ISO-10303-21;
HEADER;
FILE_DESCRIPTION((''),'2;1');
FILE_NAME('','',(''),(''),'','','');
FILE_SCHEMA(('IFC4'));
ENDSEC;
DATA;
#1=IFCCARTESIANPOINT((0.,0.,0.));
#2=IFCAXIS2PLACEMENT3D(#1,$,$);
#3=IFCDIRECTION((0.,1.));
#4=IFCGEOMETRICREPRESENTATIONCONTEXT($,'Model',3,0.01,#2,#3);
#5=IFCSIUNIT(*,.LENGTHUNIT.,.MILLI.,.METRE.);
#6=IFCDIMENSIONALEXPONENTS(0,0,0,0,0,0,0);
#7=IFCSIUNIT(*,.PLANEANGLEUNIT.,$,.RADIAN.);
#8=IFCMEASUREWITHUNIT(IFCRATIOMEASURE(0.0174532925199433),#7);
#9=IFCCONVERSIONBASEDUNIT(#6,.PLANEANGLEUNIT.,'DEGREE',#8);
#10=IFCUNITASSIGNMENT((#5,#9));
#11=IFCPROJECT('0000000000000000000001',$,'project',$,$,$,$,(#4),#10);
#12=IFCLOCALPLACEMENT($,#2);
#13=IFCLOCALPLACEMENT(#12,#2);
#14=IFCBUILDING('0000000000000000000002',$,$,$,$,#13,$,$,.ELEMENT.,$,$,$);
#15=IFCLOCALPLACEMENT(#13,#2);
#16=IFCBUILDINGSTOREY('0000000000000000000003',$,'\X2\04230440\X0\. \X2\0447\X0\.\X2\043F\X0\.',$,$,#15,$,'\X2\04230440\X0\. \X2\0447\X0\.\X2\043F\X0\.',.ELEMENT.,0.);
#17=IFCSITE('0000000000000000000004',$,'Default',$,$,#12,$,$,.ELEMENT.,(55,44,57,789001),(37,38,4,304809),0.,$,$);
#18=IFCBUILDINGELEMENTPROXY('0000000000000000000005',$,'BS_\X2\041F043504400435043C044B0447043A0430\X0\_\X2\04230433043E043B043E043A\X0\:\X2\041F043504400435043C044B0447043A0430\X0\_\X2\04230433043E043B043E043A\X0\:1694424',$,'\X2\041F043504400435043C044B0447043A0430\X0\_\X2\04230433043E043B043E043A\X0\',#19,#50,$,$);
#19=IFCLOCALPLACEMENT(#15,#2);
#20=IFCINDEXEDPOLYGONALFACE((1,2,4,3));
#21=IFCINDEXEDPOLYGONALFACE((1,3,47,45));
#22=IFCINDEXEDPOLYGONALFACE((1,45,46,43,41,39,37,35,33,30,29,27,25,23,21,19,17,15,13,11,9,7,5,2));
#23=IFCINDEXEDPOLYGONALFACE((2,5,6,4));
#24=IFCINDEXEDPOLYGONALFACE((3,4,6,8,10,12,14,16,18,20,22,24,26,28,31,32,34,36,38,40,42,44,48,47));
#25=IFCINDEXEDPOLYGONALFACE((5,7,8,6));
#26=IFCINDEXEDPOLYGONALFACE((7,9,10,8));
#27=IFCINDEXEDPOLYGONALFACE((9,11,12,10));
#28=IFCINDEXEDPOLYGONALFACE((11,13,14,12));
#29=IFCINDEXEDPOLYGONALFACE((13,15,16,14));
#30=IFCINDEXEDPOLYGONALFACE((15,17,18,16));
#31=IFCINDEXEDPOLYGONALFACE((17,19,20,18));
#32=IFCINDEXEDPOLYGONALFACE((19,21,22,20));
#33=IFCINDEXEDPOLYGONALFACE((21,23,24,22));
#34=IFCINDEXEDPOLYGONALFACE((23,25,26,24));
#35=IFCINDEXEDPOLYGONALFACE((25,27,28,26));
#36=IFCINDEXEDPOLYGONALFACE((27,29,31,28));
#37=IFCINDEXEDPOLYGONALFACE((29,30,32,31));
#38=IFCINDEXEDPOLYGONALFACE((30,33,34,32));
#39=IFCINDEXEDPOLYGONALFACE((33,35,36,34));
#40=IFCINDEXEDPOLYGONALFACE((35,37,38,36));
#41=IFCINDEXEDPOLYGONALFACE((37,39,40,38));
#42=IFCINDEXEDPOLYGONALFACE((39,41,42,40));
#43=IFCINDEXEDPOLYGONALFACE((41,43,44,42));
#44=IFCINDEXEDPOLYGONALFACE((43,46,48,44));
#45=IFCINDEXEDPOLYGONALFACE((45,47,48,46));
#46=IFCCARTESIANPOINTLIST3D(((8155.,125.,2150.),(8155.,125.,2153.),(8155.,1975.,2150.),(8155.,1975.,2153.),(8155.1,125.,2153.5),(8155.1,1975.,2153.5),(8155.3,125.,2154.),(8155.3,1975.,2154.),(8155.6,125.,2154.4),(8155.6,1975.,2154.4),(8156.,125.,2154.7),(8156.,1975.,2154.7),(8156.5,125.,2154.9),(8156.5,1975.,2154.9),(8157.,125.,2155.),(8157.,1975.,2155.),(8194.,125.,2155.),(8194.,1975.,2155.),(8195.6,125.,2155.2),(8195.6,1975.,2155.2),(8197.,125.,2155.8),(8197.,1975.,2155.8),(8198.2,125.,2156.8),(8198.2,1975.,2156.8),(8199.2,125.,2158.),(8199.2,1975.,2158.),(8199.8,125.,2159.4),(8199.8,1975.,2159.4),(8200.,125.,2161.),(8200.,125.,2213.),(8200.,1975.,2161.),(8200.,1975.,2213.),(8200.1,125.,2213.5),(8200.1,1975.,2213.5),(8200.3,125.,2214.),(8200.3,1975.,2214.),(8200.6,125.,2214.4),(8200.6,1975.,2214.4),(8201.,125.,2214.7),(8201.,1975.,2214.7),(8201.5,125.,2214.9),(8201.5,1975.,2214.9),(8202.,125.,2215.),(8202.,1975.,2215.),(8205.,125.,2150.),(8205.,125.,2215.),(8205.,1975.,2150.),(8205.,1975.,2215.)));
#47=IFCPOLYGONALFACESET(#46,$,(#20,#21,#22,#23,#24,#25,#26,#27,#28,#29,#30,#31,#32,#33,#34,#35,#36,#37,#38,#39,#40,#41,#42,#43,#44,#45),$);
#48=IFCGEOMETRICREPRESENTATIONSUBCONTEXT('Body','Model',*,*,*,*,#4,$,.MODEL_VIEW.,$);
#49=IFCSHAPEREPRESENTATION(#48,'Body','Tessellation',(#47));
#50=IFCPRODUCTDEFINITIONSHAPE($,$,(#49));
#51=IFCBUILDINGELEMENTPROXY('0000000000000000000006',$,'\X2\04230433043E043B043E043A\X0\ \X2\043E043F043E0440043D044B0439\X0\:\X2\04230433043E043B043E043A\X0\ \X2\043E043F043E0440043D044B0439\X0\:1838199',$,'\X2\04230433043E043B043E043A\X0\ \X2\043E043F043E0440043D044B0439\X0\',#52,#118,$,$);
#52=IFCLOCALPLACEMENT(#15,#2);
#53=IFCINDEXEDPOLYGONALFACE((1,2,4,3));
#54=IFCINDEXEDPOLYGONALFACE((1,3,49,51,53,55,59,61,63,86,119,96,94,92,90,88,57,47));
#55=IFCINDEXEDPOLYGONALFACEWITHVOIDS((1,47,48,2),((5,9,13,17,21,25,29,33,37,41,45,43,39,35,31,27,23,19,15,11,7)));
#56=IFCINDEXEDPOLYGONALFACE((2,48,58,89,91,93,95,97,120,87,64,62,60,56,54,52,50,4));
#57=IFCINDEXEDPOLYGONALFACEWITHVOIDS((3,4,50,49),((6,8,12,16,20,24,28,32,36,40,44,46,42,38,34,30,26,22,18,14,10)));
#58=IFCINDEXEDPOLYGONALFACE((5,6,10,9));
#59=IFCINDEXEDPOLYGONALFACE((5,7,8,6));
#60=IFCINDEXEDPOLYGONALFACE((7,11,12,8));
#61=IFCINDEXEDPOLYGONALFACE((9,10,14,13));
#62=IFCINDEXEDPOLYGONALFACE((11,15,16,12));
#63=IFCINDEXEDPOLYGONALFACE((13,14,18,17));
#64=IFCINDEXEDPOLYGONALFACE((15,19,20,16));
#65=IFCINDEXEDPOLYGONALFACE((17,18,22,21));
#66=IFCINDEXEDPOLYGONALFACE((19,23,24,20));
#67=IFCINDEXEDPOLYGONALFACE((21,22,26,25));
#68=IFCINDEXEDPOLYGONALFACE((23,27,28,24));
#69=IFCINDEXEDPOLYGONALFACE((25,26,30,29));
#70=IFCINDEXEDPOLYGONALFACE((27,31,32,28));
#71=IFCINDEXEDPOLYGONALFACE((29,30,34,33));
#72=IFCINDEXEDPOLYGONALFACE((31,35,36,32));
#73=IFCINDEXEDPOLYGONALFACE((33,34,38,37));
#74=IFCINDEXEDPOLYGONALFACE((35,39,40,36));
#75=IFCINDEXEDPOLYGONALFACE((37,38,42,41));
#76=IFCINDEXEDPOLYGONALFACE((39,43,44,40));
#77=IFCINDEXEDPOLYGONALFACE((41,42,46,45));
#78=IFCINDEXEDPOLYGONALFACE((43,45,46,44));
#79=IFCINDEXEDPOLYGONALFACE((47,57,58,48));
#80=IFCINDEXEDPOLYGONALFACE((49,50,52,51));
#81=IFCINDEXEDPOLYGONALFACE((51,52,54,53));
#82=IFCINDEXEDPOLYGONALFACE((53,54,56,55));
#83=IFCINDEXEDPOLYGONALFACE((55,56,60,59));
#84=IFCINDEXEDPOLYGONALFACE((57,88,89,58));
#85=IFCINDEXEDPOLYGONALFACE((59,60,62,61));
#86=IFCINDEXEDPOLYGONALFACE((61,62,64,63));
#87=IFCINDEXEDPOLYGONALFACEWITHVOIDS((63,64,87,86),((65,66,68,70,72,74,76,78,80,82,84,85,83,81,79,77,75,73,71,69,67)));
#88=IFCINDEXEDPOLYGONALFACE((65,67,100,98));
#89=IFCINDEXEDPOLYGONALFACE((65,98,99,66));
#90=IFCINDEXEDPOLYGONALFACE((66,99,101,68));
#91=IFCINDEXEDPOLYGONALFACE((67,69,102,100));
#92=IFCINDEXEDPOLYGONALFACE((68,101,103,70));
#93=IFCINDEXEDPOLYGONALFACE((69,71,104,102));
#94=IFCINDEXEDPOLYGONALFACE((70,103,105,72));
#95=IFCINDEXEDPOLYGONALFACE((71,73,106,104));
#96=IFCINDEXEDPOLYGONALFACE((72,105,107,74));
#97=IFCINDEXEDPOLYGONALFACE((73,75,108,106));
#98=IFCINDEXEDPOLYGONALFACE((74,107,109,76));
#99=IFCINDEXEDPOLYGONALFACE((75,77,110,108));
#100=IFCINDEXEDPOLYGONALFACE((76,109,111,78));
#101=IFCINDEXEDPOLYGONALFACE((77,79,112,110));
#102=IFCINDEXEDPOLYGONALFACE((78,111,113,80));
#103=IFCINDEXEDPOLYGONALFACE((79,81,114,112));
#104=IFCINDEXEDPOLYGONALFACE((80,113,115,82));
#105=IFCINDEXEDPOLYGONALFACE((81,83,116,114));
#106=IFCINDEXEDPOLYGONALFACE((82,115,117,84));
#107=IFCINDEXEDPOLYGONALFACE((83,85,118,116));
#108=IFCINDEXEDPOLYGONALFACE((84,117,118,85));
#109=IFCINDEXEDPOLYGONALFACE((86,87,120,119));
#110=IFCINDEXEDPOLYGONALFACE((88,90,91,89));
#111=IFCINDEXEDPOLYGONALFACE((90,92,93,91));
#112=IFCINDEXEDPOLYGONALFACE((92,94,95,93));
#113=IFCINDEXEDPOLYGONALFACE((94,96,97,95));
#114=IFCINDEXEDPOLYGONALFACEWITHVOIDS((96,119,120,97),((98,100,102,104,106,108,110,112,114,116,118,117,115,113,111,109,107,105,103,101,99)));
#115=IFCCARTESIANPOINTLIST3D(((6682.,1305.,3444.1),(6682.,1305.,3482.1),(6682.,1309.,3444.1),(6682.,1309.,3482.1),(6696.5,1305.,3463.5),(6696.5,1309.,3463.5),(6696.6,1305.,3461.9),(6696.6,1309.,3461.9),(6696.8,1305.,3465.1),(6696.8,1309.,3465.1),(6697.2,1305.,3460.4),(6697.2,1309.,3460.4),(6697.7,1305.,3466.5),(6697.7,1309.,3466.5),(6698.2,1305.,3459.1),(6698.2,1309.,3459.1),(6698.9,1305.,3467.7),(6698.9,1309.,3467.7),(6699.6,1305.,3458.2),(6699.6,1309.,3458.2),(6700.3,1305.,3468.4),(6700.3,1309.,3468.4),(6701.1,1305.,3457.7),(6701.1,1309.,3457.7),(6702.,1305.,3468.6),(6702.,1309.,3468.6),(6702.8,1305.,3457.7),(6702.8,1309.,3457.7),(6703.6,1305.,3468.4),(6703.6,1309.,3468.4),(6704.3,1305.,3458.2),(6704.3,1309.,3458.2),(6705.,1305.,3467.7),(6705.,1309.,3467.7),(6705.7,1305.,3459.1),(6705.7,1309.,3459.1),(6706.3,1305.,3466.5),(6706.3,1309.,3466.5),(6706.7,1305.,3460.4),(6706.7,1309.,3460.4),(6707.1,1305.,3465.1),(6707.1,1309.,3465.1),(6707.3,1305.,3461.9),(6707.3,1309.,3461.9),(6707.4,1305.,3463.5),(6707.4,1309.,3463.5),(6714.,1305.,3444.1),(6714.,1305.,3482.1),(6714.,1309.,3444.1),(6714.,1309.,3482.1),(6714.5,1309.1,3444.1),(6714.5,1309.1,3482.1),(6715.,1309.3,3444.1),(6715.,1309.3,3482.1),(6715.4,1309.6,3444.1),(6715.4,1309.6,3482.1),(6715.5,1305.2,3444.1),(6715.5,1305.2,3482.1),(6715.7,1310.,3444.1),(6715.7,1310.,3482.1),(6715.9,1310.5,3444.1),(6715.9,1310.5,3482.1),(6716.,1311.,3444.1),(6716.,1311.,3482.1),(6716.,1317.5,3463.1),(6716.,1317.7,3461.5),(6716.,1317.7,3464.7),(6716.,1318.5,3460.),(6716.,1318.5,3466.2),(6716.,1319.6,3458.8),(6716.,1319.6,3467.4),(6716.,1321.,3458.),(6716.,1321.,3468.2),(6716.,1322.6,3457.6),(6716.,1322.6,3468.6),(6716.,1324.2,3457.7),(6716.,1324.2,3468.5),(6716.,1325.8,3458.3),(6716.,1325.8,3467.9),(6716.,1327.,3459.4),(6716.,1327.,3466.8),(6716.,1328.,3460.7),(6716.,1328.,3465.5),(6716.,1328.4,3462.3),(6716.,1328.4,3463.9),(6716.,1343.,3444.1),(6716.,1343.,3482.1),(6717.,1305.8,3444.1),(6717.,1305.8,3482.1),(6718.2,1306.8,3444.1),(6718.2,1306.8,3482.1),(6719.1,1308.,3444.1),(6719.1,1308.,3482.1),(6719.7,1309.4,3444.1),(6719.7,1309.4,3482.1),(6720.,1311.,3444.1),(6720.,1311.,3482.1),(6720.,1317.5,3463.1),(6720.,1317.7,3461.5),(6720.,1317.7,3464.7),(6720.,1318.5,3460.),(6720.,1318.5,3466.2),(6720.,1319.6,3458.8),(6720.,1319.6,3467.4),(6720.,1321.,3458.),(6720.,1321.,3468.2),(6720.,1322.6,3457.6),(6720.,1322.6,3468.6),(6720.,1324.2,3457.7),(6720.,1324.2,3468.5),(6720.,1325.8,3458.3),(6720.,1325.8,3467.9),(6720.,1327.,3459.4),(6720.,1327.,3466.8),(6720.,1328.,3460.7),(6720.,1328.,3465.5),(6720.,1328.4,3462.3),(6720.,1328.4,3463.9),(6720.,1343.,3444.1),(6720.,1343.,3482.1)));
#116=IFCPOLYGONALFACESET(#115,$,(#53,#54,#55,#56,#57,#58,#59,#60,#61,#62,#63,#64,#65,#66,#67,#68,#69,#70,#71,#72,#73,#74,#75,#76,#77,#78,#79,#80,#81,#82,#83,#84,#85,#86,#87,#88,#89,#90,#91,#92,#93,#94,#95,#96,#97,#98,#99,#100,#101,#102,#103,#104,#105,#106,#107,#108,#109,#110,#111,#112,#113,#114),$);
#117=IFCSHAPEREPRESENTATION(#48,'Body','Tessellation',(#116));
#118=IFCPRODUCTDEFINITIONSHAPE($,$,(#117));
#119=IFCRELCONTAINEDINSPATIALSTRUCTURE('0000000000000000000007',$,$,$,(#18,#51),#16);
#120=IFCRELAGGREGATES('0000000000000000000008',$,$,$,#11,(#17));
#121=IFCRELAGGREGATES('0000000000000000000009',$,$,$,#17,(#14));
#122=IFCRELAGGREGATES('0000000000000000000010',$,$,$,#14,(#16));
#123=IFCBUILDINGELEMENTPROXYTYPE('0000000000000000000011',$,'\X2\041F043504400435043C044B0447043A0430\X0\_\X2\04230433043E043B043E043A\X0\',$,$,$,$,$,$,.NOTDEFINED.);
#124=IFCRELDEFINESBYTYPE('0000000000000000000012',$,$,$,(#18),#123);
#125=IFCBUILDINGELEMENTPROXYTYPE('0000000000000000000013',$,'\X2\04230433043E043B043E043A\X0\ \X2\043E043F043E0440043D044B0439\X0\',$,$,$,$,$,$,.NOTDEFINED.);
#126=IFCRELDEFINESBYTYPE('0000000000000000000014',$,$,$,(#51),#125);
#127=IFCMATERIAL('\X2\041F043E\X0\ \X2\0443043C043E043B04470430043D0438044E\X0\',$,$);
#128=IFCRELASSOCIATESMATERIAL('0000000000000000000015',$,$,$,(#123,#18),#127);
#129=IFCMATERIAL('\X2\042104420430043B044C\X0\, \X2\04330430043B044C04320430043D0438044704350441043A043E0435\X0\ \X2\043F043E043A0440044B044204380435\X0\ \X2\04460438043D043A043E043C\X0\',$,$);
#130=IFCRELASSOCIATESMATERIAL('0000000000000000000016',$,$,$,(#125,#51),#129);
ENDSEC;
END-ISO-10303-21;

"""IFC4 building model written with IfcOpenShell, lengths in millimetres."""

from ifc_helpers import new_model, entity, si_unit, converted_unit, direction, frame, frame_2d, origin, place, context, subcontext, project, spatial, polyline, circle_curve, parameter, trimmed, segment, composite_curve, circle, outline, extrude, source, transform, mapped, material, type_object, type_shapes, element, save


model = new_model("IFC4")

# Units and contexts
model_context = context("Model", 3, precision=0.01, world=origin(), true_north=direction((0.0, 1.0)))
body_context = subcontext(model_context, "Body", "Model", "MODEL_VIEW")
ifc_project = project(units=[si_unit("LENGTHUNIT", "METRE", prefix="MILLI"), converted_unit("PLANEANGLEUNIT", "DEGREE", entity("IfcRatioMeasure", 0.0174532925199433), si_unit("PLANEANGLEUNIT", "RADIAN"), dimensions=[0, 0, 0, 0, 0, 0, 0])], contexts=[model_context])

# Site, building, storey
site_placement = place(None, origin())
site = spatial("IfcSite", under=ifc_project, at=site_placement, Name="Default", CompositionType="ELEMENT", RefLatitude=(55, 44, 57, 789001), RefLongitude=(37, 38, 4, 304809), RefElevation=0.0)
building_placement = place(site_placement, origin())
building = spatial("IfcBuilding", under=site, at=building_placement, CompositionType="ELEMENT")
storey_placement = place(building_placement, origin())
storey = spatial("IfcBuildingStorey", under=building, at=storey_placement, Name="Ур. ч.п.", LongName="Ур. ч.п.", CompositionType="ELEMENT", Elevation=0.0)

# Building element proxy
ifc_material_1 = material(Name="По умолчанию")
building_element_proxy_type_1 = type_object("IfcBuildingElementProxyType", Name="Перемычка_Уголок", material=ifc_material_1)
shared_shape_1 = source(origin(), body_context, "Body", "SweptSolid", [
    extrude(outline(composite_curve([segment(polyline([(-24.1, -19.1), (40.9, -19.1)]), True, "CONTINUOUS"), segment(polyline([(40.9, -19.1), (40.9, -16.1)]), True, "CONTINUOUS"), segment(trimmed(circle_curve(frame_2d((38.9, -16.1), x_axis=(0.0, 1.0)), 2.0), [parameter(270.0)], [parameter(0.0)], True, "PARAMETER"), True, "CONTINUOUS"), segment(polyline([(38.9, -14.1), (-13.1, -14.1)]), True, "CONTINUOUS"), segment(trimmed(circle_curve(frame_2d((-13.1, -8.1), x_axis=(0.0, 1.0)), 6.0), [parameter(90.0)], [parameter(180.0)], True, "PARAMETER"), False, "CONTINUOUS"), segment(polyline([(-19.1, -8.1), (-19.1, 28.9)]), True, "CONTINUOUS"), segment(trimmed(circle_curve(frame_2d((-21.1, 28.9), x_axis=(0.0, 1.0)), 2.0), [parameter(270.0)], [parameter(0.0)], True, "PARAMETER"), True, "CONTINUOUS"), segment(polyline([(-21.1, 30.9), (-24.1, 30.9)]), True, "CONTINUOUS"), segment(polyline([(-24.1, 30.9), (-24.1, -19.1)]), True, "CONTINUOUS")], self_intersect=False)), frame((0.0, 32.5, 24.1), z_axis=(1.0, 0.0, 0.0), x_axis=(0.0, 0.0, 1.0)), (0.0, 0.0, 1.0), 1850.0),
])
type_shapes(building_element_proxy_type_1, [shared_shape_1])
proxy_1_placement = place(storey_placement, frame((8153.4, 1975.0, 2150.0), z_axis=(0.0, 0.0, 1.0), x_axis=(0.0, -1.0, 0.0)))
element("IfcBuildingElementProxy", 1, at=proxy_1_placement, inside=storey, type_object=building_element_proxy_type_1, material=ifc_material_1, Name="BS_Перемычка_Уголок:Перемычка_Уголок:1694424", ObjectType="Перемычка_Уголок", context=body_context, shape_type="MappedRepresentation", body=[
    mapped(shared_shape_1, transform((0.0, 0.0, 0.0), scale=1.0)),
])

# Building element proxy, openings
ifc_material_2 = material(Name="Сталь, гальваническое покрытие цинком")
building_element_proxy_type_2 = type_object("IfcBuildingElementProxyType", Name="Уголок опорный", material=ifc_material_2)
shared_shape_2 = source(origin(), body_context, "Body", "SweptSolid", [
    extrude(outline(composite_curve([segment(polyline([(-6.0, -12.0), (26.0, -12.0)]), True, "CONTINUOUS"), segment(polyline([(26.0, -12.0), (26.0, -8.0)]), True, "CONTINUOUS"), segment(polyline([(26.0, -8.0), (-6.0, -8.0)]), True, "CONTINUOUS"), segment(trimmed(circle_curve(frame_2d((-6.0, -6.0), x_axis=(0.0, -1.0)), 2.0), [parameter(270.0)], [parameter(0.0)], True, "PARAMETER"), False, "CONTINUOUS"), segment(polyline([(-8.0, -6.0), (-8.0, 26.0)]), True, "CONTINUOUS"), segment(polyline([(-8.0, 26.0), (-12.0, 26.0)]), True, "CONTINUOUS"), segment(polyline([(-12.0, 26.0), (-12.0, -6.0)]), True, "CONTINUOUS"), segment(trimmed(circle_curve(frame_2d((-6.0, -6.0), x_axis=(0.0, -1.0)), 6.0), [parameter(270.0)], [parameter(360.0)], True, "PARAMETER"), True, "CONTINUOUS")], self_intersect=False)), frame((12.0, -19.0, 12.0), z_axis=(0.0, 1.0, 0.0), x_axis=(0.0, 0.0, 1.0)), (0.0, 0.0, 1.0), 38.0),
])
type_shapes(building_element_proxy_type_2, [shared_shape_2])
proxy_2_placement = place(storey_placement, frame((6720.0, 1305.0, 3463.1), z_axis=(0.0, 1.0, 0.0), x_axis=(-1.0, 0.0, 0.0)))
proxy_2 = element("IfcBuildingElementProxy", 2, at=proxy_2_placement, inside=storey, type_object=building_element_proxy_type_2, material=ifc_material_2, Name="Уголок опорный:Уголок опорный:1838199", ObjectType="Уголок опорный", context=body_context, shape_type="MappedRepresentation", body=[
    mapped(shared_shape_2, transform((0.0, 0.0, 0.0), scale=1.0)),
])
opening_1_placement = place(storey_placement, frame((6720.0, 1305.0, 3463.1)))
element("IfcOpeningElement", 3, at=opening_1_placement, cuts=proxy_2, ObjectType="Opening", PredefinedType="OPENING", context=body_context, shape_type="SweptSolid", body=[
    extrude(circle(Radius=5.5, at=frame_2d((0.0, 0.0), x_axis=(1.0, 0.0))), frame((-4.0, 18.0, 0.0), z_axis=(1.0, 0.0, 0.0), x_axis=(0.0, -1.0, 0.0)), (0.0, 0.0, 1.0), 4.0),
])
opening_2_placement = place(storey_placement, frame((6720.0, 1305.0, 3463.1)))
element("IfcOpeningElement", 4, at=opening_2_placement, cuts=proxy_2, ObjectType="Opening", PredefinedType="OPENING", context=body_context, shape_type="SweptSolid", body=[
    extrude(circle(Radius=5.5, at=frame_2d((0.0, 0.0), x_axis=(1.0, 0.0))), frame((-18.0, 0.0, 0.0), z_axis=(0.0, 1.0, 0.0), x_axis=(0.0, 0.0, 1.0)), (0.0, 0.0, 1.0), 4.0),
])

save(model, "model.ifc")
